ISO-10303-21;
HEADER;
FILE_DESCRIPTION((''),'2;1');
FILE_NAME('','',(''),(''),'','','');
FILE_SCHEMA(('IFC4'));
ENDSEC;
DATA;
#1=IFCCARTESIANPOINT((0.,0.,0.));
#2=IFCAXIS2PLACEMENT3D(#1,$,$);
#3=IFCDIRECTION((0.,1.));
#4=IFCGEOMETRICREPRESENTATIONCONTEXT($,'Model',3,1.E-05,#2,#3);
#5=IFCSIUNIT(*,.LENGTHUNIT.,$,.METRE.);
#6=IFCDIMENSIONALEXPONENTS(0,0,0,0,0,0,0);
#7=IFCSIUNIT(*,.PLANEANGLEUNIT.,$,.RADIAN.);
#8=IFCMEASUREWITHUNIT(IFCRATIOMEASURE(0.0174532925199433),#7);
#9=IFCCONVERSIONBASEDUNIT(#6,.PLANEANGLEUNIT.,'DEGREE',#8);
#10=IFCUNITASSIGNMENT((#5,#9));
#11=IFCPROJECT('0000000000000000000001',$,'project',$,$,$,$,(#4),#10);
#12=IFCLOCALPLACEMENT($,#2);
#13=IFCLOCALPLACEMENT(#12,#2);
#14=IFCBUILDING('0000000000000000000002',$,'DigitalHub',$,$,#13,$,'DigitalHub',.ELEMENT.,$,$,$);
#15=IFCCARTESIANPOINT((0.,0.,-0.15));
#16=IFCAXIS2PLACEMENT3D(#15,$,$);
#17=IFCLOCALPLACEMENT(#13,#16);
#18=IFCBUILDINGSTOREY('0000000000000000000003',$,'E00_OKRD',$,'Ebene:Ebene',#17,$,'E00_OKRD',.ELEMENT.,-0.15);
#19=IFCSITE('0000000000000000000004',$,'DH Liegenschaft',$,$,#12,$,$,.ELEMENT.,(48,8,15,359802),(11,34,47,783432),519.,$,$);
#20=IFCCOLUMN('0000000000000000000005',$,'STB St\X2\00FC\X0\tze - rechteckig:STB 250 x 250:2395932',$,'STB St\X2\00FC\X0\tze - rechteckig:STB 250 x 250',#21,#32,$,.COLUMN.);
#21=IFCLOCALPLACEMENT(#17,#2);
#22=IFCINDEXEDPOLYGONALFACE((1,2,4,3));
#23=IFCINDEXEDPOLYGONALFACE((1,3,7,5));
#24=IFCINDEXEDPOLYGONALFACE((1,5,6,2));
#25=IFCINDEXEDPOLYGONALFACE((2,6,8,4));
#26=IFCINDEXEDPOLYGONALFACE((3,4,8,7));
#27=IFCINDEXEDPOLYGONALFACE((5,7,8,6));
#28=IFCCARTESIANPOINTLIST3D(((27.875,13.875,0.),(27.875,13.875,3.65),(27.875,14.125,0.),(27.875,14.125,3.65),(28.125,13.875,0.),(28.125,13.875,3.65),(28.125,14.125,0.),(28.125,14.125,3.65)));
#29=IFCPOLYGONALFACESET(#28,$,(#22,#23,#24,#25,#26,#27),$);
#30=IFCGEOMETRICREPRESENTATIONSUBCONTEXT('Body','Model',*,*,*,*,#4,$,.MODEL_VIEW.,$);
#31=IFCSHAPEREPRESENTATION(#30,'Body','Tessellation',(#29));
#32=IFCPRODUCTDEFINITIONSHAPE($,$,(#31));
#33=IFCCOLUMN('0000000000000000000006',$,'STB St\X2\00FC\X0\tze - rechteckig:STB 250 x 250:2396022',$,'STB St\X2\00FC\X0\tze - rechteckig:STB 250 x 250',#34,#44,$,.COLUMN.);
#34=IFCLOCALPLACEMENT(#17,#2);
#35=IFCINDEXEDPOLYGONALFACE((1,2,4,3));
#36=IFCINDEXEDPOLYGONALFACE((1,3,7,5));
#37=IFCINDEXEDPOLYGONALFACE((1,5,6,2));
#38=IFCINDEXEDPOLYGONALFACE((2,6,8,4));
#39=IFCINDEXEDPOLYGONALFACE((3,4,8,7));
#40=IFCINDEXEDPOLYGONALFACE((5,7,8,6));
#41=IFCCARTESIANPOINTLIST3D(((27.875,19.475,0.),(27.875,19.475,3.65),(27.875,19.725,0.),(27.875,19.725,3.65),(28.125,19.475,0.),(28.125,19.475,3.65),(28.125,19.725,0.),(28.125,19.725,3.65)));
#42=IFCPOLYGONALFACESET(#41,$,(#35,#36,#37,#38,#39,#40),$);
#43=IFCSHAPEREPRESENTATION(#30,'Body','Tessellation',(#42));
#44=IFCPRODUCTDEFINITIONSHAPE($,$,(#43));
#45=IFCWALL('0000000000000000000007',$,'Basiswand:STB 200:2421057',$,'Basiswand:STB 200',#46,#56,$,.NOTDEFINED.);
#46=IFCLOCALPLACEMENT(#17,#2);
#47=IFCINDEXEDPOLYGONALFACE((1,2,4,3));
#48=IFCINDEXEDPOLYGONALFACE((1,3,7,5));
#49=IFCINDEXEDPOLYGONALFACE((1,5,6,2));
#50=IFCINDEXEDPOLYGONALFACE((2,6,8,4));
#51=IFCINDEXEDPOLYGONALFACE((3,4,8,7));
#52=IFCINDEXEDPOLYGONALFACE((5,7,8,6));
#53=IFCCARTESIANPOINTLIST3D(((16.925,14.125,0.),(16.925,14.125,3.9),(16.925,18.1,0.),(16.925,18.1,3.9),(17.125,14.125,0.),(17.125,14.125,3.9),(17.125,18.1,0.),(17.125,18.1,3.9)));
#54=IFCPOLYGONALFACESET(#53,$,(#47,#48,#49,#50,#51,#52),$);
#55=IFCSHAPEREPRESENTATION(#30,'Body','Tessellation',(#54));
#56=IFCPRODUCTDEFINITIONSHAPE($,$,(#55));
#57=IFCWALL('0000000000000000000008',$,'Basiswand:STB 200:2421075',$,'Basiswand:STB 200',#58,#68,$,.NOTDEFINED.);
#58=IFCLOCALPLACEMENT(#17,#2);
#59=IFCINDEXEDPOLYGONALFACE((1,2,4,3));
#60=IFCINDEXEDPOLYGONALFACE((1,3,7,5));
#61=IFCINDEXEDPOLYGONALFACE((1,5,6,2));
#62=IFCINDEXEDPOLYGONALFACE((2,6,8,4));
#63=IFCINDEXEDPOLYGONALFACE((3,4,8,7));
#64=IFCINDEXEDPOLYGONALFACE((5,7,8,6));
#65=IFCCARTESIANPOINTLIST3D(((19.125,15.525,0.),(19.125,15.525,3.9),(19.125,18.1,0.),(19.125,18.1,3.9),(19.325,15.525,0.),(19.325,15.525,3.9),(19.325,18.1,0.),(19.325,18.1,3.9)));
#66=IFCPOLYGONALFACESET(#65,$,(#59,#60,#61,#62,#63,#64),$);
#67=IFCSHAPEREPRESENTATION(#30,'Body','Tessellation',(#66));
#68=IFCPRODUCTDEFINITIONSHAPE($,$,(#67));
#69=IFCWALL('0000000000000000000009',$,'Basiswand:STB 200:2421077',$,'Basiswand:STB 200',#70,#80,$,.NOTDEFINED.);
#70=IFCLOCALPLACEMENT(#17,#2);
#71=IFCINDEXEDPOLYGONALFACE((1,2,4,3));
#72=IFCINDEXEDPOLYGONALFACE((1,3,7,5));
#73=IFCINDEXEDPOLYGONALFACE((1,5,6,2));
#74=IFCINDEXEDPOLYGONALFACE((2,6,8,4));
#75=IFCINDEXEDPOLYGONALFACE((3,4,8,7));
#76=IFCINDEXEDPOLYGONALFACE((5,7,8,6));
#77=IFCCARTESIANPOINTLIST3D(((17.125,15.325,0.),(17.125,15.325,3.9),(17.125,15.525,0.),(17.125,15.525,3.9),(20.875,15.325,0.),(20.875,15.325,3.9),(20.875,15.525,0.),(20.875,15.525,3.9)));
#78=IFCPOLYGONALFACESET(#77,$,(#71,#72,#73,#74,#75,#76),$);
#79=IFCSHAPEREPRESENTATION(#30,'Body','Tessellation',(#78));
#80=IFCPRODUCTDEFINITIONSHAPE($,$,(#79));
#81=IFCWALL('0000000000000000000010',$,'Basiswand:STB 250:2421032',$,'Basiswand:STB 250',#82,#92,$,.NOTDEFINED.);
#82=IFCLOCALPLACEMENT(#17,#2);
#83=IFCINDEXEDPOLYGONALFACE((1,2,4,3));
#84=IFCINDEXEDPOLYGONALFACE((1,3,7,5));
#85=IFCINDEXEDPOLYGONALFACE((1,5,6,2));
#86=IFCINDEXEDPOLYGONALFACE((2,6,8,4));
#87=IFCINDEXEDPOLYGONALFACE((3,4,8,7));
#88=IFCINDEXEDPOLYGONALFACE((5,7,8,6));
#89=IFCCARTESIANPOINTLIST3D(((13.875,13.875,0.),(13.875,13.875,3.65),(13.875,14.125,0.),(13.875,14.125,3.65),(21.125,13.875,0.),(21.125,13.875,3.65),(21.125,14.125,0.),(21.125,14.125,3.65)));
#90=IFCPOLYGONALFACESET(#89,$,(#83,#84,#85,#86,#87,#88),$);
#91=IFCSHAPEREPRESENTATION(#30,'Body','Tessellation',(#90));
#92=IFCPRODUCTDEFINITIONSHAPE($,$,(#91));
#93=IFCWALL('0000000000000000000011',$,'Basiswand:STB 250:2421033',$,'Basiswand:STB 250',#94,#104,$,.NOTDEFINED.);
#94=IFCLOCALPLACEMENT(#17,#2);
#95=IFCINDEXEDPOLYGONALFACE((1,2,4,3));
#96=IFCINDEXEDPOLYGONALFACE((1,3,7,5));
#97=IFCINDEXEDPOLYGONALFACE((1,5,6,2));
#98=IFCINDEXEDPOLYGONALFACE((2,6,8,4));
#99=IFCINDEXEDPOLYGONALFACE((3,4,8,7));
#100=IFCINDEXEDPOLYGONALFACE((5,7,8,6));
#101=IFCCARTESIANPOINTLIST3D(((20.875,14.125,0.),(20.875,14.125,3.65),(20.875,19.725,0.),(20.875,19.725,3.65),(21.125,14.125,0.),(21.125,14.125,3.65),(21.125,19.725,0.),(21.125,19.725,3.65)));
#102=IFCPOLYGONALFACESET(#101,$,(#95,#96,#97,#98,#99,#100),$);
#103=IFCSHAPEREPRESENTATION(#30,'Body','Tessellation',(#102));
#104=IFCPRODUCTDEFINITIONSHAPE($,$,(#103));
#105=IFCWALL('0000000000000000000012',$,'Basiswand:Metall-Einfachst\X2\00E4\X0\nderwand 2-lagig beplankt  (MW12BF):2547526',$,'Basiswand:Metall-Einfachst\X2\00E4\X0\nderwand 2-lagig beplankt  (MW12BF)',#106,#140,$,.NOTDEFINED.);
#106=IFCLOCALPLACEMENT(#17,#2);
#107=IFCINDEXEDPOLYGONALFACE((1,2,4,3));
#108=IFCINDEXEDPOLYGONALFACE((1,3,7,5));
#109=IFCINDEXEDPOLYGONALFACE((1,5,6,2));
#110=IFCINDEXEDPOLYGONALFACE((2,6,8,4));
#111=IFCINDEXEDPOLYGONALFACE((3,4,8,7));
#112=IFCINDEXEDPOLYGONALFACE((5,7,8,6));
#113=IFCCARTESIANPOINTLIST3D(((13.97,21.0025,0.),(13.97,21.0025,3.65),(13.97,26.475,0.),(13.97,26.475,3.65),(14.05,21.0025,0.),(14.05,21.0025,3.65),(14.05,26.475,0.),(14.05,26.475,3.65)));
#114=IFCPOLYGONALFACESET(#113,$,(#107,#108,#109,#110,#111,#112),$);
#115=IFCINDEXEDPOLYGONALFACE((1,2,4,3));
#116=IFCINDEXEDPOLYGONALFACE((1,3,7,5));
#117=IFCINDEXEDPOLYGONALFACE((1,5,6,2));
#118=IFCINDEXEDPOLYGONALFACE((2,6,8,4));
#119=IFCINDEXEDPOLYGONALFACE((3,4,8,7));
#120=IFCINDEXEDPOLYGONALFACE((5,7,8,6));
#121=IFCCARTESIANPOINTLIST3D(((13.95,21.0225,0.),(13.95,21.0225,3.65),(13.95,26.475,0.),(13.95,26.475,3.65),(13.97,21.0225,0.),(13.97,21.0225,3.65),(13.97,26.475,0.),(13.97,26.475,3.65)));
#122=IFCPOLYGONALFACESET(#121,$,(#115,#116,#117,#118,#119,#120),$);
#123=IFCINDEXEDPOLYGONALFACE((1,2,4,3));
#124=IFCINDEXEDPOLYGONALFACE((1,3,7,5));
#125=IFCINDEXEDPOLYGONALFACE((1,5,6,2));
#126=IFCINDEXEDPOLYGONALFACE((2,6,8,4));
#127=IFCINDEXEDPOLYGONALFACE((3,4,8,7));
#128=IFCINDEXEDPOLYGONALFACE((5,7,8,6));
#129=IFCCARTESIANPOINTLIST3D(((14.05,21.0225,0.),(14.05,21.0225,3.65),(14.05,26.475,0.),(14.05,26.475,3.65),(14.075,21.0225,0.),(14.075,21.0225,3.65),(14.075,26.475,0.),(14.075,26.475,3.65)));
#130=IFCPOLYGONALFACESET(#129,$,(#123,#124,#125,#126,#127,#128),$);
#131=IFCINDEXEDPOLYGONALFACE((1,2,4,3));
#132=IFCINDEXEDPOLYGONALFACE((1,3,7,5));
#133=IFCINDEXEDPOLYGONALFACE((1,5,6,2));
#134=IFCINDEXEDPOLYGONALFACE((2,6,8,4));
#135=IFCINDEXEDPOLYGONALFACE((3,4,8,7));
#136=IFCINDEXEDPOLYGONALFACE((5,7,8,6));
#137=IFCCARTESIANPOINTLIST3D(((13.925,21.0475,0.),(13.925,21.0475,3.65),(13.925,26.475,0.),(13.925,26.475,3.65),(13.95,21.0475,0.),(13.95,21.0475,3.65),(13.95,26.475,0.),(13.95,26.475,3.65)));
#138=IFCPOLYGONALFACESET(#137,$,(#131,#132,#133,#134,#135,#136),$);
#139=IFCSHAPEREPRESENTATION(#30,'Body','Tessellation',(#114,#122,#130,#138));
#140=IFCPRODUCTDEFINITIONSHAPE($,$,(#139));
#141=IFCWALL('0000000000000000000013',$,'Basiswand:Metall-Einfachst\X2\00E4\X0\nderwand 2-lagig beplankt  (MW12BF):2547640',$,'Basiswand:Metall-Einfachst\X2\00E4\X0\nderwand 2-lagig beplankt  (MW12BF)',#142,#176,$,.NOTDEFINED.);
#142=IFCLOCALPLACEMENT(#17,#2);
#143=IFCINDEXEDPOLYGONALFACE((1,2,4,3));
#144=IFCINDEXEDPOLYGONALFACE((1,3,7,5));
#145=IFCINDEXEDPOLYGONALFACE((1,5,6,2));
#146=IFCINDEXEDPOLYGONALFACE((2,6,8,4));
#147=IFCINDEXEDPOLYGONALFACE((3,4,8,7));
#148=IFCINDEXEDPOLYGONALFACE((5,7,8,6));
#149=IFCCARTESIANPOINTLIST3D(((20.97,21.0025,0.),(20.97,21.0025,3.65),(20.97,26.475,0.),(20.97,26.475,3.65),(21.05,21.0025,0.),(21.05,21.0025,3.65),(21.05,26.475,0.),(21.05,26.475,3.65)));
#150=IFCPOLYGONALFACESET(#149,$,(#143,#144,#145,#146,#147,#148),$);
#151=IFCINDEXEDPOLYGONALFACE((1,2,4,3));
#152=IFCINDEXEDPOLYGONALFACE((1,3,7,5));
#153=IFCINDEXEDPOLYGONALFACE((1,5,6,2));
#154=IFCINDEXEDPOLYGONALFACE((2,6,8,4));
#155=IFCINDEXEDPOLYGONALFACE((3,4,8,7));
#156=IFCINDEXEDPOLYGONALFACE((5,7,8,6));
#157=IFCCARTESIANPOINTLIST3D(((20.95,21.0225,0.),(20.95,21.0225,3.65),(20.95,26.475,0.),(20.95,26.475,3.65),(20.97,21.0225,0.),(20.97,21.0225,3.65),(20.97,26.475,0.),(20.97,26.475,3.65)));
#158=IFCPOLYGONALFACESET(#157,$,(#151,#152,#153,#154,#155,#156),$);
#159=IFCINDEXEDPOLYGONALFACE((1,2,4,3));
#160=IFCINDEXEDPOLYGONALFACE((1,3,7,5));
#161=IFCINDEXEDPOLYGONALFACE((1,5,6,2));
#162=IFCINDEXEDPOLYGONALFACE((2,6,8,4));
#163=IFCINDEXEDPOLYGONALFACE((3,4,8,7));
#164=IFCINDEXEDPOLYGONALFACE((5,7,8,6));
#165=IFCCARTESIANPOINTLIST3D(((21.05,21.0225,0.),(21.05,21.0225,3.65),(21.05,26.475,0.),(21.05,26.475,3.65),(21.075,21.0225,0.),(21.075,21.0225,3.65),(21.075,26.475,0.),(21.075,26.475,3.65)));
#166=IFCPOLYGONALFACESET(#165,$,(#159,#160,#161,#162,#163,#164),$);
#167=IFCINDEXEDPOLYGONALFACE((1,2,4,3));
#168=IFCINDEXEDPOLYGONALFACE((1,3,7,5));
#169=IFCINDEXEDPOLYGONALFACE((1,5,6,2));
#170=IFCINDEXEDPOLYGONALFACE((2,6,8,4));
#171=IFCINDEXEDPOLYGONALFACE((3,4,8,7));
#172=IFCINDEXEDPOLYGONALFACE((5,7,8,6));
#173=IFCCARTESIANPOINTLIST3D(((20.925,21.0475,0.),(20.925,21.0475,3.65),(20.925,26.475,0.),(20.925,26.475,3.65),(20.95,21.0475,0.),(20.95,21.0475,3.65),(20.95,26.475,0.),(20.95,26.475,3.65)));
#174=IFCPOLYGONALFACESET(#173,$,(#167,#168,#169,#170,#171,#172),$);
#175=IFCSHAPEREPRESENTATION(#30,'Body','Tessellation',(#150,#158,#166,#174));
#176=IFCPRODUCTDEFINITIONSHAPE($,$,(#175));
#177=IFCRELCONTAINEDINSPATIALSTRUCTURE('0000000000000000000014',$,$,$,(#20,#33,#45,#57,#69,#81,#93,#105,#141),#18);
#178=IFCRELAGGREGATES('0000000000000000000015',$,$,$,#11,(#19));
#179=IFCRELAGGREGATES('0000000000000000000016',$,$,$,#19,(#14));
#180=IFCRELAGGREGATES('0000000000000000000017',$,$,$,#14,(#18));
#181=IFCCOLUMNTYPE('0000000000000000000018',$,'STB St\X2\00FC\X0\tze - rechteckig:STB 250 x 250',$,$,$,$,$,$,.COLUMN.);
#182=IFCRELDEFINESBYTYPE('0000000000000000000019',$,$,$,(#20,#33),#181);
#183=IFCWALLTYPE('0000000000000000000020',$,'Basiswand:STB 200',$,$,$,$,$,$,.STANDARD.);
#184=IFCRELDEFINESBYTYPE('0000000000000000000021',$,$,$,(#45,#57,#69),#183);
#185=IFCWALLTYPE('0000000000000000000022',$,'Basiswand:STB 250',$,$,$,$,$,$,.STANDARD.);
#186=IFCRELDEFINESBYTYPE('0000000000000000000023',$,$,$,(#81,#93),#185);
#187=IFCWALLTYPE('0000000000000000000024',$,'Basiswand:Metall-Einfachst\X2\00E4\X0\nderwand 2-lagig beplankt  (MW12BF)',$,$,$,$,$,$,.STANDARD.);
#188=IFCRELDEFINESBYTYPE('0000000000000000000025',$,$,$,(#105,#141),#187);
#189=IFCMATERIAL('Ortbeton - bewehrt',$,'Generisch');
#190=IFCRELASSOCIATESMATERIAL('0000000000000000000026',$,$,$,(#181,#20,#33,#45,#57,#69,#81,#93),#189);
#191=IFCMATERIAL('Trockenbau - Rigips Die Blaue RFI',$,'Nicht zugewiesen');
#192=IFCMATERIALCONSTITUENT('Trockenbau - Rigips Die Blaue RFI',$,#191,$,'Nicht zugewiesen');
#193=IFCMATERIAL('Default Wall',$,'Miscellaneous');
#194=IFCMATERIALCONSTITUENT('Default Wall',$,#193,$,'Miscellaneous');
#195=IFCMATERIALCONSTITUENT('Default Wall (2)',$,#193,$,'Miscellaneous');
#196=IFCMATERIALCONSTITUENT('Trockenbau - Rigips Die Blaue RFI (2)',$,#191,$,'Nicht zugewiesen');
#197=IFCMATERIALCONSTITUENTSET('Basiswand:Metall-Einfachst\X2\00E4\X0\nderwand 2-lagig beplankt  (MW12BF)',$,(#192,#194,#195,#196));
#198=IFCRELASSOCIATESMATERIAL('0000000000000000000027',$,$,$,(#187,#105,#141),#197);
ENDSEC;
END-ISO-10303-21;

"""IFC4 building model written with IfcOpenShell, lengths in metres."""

from ifc_helpers import new_model, entity, si_unit, converted_unit, direction, frame, origin, place, context, subcontext, project, spatial, indexed_curve, outline, extrude, source, transform, mapped, material, constituent, constituent_set, type_object, type_shapes, element, save


model = new_model("IFC4")

# Units and contexts
model_context = context("Model", 3, precision=1e-05, world=origin(), true_north=direction((0.0, 1.0)))
body_context = subcontext(model_context, "Body", "Model", "MODEL_VIEW")
ifc_project = project(units=[si_unit("LENGTHUNIT", "METRE"), converted_unit("PLANEANGLEUNIT", "DEGREE", entity("IfcRatioMeasure", 0.0174532925199433), si_unit("PLANEANGLEUNIT", "RADIAN"), dimensions=[0, 0, 0, 0, 0, 0, 0])], contexts=[model_context])

# Site, building, storey
site_placement = place(None, frame((0.0, 0.0, 0.0)))
site = spatial("IfcSite", under=ifc_project, at=site_placement, Name="DH Liegenschaft", CompositionType="ELEMENT", RefLatitude=(48, 8, 15, 359802), RefLongitude=(11, 34, 47, 783432), RefElevation=519.0)
building_placement = place(site_placement, origin())
building = spatial("IfcBuilding", under=site, at=building_placement, Name="DigitalHub", LongName="DigitalHub", CompositionType="ELEMENT")
storey_placement = place(building_placement, frame((0.0, 0.0, -0.15)))
storey = spatial("IfcBuildingStorey", under=building, at=storey_placement, Name="E00_OKRD", ObjectType="Ebene:Ebene", LongName="E00_OKRD", CompositionType="ELEMENT", Elevation=-0.15)

# Columns
ifc_material_1 = material(Name="Ortbeton - bewehrt", Category="Generisch")
column_type = type_object("IfcColumnType", Name="STB Stütze - rechteckig:STB 250 x 250", PredefinedType="COLUMN", material=ifc_material_1)
shared_shape = source(origin(), body_context, "Body", "SweptSolid", [
    extrude(outline(indexed_curve([(-0.125, -0.125), (0.125, -0.125), (0.125, 0.125), (-0.125, 0.125), (-0.125, -0.125)], self_intersect=False)), frame((0.0, 0.0, -0.15), z_axis=(0.0, 0.0, 1.0), x_axis=(0.0, -1.0, 0.0)), (0.0, 0.0, 1.0), 3.65),
])
type_shapes(column_type, [shared_shape])
for number, where, name in (
    (1, (28.0, 14.0, 0.15), "STB Stütze - rechteckig:STB 250 x 250:2395932"),
    (2, (28.0, 19.6, 0.15), "STB Stütze - rechteckig:STB 250 x 250:2396022"),
):
    element("IfcColumn", number, at=place(storey_placement, frame(where)), inside=storey, type_object=column_type, material=ifc_material_1, Name=name, ObjectType="STB Stütze - rechteckig:STB 250 x 250", PredefinedType="COLUMN", context=body_context, shape_type="MappedRepresentation", body=[
        mapped(shared_shape, transform((0.0, 0.0, 0.0), scale=1.0)),
    ])

# Walls
wall_type_1 = type_object("IfcWallType", Name="Basiswand:STB 200", PredefinedType="STANDARD")
wall_1_placement = place(storey_placement, frame((17.025, 14.125, 0.0), z_axis=(0.0, 0.0, 1.0), x_axis=(0.0, 1.0, 0.0)))
element("IfcWall", 3, at=wall_1_placement, inside=storey, type_object=wall_type_1, material=ifc_material_1, Name="Basiswand:STB 200:2421057", ObjectType="Basiswand:STB 200", PredefinedType="NOTDEFINED", context=body_context, shape_type="SweptSolid", body=[
    extrude(outline(indexed_curve([(3.975, 0.1), (0.0, 0.1), (0.0, -0.1), (3.975, -0.1), (3.975, 0.1)], self_intersect=False)), origin(), (0.0, 0.0, 1.0), 3.9),
])
wall_2_placement = place(storey_placement, frame((19.225, 15.525, 0.0), z_axis=(0.0, 0.0, 1.0), x_axis=(0.0, 1.0, 0.0)))
element("IfcWall", 4, at=wall_2_placement, inside=storey, type_object=wall_type_1, material=ifc_material_1, Name="Basiswand:STB 200:2421075", ObjectType="Basiswand:STB 200", PredefinedType="NOTDEFINED", context=body_context, shape_type="SweptSolid", body=[
    extrude(outline(indexed_curve([(2.575, 0.1), (0.0, 0.1), (0.0, -0.1), (2.575, -0.1), (2.575, 0.1)], self_intersect=False)), origin(), (0.0, 0.0, 1.0), 3.9),
])
wall_3_placement = place(storey_placement, frame((17.125, 15.425, 0.0)))
element("IfcWall", 5, at=wall_3_placement, inside=storey, type_object=wall_type_1, material=ifc_material_1, Name="Basiswand:STB 200:2421077", ObjectType="Basiswand:STB 200", PredefinedType="NOTDEFINED", context=body_context, shape_type="SweptSolid", body=[
    extrude(outline(indexed_curve([(3.75, 0.1), (0.0, 0.1), (0.0, -0.1), (3.75, -0.1), (3.75, 0.1)], self_intersect=False)), origin(), (0.0, 0.0, 1.0), 3.9),
])
wall_type_2 = type_object("IfcWallType", Name="Basiswand:STB 250", PredefinedType="STANDARD")
wall_4_placement = place(storey_placement, frame((13.875, 14.0, 0.0)))
element("IfcWall", 6, at=wall_4_placement, inside=storey, type_object=wall_type_2, material=ifc_material_1, Name="Basiswand:STB 250:2421032", ObjectType="Basiswand:STB 250", PredefinedType="NOTDEFINED", context=body_context, shape_type="SweptSolid", body=[
    extrude(outline(indexed_curve([(7.25, 0.125), (0.0, 0.125), (0.0, -0.125), (7.25, -0.125), (7.25, 0.125)], self_intersect=False)), origin(), (0.0, 0.0, 1.0), 3.65),
])
wall_5_placement = place(storey_placement, frame((21.0, 14.125, 0.0), z_axis=(0.0, 0.0, 1.0), x_axis=(0.0, 1.0, 0.0)))
element("IfcWall", 7, at=wall_5_placement, inside=storey, type_object=wall_type_2, material=ifc_material_1, Name="Basiswand:STB 250:2421033", ObjectType="Basiswand:STB 250", PredefinedType="NOTDEFINED", context=body_context, shape_type="SweptSolid", body=[
    extrude(outline(indexed_curve([(5.6, 0.125), (0.0, 0.125), (0.0, -0.125), (5.6, -0.125), (5.6, 0.125)], self_intersect=False)), origin(), (0.0, 0.0, 1.0), 3.65),
])
ifc_material_2 = material(Name="Trockenbau - Rigips Die Blaue RFI", Category="Nicht zugewiesen")
ifc_constituent_1 = constituent(ifc_material_2, Name="Trockenbau - Rigips Die Blaue RFI", Category="Nicht zugewiesen")
ifc_material_3 = material(Name="Default Wall", Category="Miscellaneous")
ifc_constituent_2 = constituent(ifc_material_3, Name="Default Wall", Category="Miscellaneous")
ifc_constituent_3 = constituent(ifc_material_3, Name="Default Wall (2)", Category="Miscellaneous")
ifc_constituent_4 = constituent(ifc_material_2, Name="Trockenbau - Rigips Die Blaue RFI (2)", Category="Nicht zugewiesen")
ifc_constituent_set_1 = constituent_set(constituents=[ifc_constituent_1, ifc_constituent_2, ifc_constituent_3, ifc_constituent_4], Name="Basiswand:Metall-Einfachständerwand 2-lagig beplankt  (MW12BF)")
wall_type_3 = type_object("IfcWallType", Name="Basiswand:Metall-Einfachständerwand 2-lagig beplankt  (MW12BF)", PredefinedType="STANDARD", material=ifc_constituent_set_1)
wall_6_placement = place(storey_placement, frame((14.0, 26.475, 0.0), z_axis=(0.0, 0.0, 1.0), x_axis=(0.0, -1.0, 0.0)))
element("IfcWall", 8, at=wall_6_placement, inside=storey, type_object=wall_type_3, material=ifc_constituent_set_1, Name="Basiswand:Metall-Einfachständerwand 2-lagig beplankt  (MW12BF):2547526", ObjectType="Basiswand:Metall-Einfachständerwand 2-lagig beplankt  (MW12BF)", PredefinedType="NOTDEFINED", context=body_context, shape_type="SweptSolid", body=[
    extrude(outline(indexed_curve([(-2.7362, -0.04), (2.7362, -0.04), (2.7362, 0.04), (-2.7362, 0.04), (-2.7362, -0.04)], self_intersect=False)), frame((2.7362, 0.01, 0.0)), (0.0, 0.0, 1.0), 3.65),
    extrude(outline(indexed_curve([(-2.7262, -0.01), (2.7262, -0.01), (2.7262, 0.01), (-2.7262, 0.01), (-2.7262, -0.01)], self_intersect=False)), frame((2.7262, -0.04, 0.0)), (0.0, 0.0, 1.0), 3.65),
    extrude(outline(indexed_curve([(-0.0125, -2.7262), (0.0125, -2.7262), (0.0125, 2.7262), (-0.0125, 2.7262), (-0.0125, -2.7262)], self_intersect=False)), frame((2.7262, 0.0625, 0.0), z_axis=(0.0, 0.0, 1.0), x_axis=(0.0, -1.0, 0.0)), (0.0, 0.0, 1.0), 3.65),
    extrude(outline(indexed_curve([(-0.0125, -2.7137), (0.0125, -2.7137), (0.0125, 2.7137), (-0.0125, 2.7137), (-0.0125, -2.7137)], self_intersect=False)), frame((2.7137, -0.0625, 0.0), z_axis=(0.0, 0.0, 1.0), x_axis=(0.0, 1.0, 0.0)), (0.0, 0.0, 1.0), 3.65),
])
wall_7_placement = place(storey_placement, frame((21.0, 26.475, 0.0), z_axis=(0.0, 0.0, 1.0), x_axis=(0.0, -1.0, 0.0)))
element("IfcWall", 9, at=wall_7_placement, inside=storey, type_object=wall_type_3, material=ifc_constituent_set_1, Name="Basiswand:Metall-Einfachständerwand 2-lagig beplankt  (MW12BF):2547640", ObjectType="Basiswand:Metall-Einfachständerwand 2-lagig beplankt  (MW12BF)", PredefinedType="NOTDEFINED", context=body_context, shape_type="SweptSolid", body=[
    extrude(outline(indexed_curve([(-2.7362, -0.04), (2.7362, -0.04), (2.7362, 0.04), (-2.7362, 0.04), (-2.7362, -0.04)], self_intersect=False)), frame((2.7362, 0.01, 0.0)), (0.0, 0.0, 1.0), 3.65),
    extrude(outline(indexed_curve([(-2.7262, -0.01), (2.7262, -0.01), (2.7262, 0.01), (-2.7262, 0.01), (-2.7262, -0.01)], self_intersect=False)), frame((2.7262, -0.04, 0.0)), (0.0, 0.0, 1.0), 3.65),
    extrude(outline(indexed_curve([(-0.0125, -2.7262), (0.0125, -2.7262), (0.0125, 2.7262), (-0.0125, 2.7262), (-0.0125, -2.7262)], self_intersect=False)), frame((2.7262, 0.0625, 0.0), z_axis=(0.0, 0.0, 1.0), x_axis=(0.0, -1.0, 0.0)), (0.0, 0.0, 1.0), 3.65),
    extrude(outline(indexed_curve([(-0.0125, -2.7137), (0.0125, -2.7137), (0.0125, 2.7137), (-0.0125, 2.7137), (-0.0125, -2.7137)], self_intersect=False)), frame((2.7137, -0.0625, 0.0), z_axis=(0.0, 0.0, 1.0), x_axis=(0.0, 1.0, 0.0)), (0.0, 0.0, 1.0), 3.65),
])

save(model, "model.ifc")
